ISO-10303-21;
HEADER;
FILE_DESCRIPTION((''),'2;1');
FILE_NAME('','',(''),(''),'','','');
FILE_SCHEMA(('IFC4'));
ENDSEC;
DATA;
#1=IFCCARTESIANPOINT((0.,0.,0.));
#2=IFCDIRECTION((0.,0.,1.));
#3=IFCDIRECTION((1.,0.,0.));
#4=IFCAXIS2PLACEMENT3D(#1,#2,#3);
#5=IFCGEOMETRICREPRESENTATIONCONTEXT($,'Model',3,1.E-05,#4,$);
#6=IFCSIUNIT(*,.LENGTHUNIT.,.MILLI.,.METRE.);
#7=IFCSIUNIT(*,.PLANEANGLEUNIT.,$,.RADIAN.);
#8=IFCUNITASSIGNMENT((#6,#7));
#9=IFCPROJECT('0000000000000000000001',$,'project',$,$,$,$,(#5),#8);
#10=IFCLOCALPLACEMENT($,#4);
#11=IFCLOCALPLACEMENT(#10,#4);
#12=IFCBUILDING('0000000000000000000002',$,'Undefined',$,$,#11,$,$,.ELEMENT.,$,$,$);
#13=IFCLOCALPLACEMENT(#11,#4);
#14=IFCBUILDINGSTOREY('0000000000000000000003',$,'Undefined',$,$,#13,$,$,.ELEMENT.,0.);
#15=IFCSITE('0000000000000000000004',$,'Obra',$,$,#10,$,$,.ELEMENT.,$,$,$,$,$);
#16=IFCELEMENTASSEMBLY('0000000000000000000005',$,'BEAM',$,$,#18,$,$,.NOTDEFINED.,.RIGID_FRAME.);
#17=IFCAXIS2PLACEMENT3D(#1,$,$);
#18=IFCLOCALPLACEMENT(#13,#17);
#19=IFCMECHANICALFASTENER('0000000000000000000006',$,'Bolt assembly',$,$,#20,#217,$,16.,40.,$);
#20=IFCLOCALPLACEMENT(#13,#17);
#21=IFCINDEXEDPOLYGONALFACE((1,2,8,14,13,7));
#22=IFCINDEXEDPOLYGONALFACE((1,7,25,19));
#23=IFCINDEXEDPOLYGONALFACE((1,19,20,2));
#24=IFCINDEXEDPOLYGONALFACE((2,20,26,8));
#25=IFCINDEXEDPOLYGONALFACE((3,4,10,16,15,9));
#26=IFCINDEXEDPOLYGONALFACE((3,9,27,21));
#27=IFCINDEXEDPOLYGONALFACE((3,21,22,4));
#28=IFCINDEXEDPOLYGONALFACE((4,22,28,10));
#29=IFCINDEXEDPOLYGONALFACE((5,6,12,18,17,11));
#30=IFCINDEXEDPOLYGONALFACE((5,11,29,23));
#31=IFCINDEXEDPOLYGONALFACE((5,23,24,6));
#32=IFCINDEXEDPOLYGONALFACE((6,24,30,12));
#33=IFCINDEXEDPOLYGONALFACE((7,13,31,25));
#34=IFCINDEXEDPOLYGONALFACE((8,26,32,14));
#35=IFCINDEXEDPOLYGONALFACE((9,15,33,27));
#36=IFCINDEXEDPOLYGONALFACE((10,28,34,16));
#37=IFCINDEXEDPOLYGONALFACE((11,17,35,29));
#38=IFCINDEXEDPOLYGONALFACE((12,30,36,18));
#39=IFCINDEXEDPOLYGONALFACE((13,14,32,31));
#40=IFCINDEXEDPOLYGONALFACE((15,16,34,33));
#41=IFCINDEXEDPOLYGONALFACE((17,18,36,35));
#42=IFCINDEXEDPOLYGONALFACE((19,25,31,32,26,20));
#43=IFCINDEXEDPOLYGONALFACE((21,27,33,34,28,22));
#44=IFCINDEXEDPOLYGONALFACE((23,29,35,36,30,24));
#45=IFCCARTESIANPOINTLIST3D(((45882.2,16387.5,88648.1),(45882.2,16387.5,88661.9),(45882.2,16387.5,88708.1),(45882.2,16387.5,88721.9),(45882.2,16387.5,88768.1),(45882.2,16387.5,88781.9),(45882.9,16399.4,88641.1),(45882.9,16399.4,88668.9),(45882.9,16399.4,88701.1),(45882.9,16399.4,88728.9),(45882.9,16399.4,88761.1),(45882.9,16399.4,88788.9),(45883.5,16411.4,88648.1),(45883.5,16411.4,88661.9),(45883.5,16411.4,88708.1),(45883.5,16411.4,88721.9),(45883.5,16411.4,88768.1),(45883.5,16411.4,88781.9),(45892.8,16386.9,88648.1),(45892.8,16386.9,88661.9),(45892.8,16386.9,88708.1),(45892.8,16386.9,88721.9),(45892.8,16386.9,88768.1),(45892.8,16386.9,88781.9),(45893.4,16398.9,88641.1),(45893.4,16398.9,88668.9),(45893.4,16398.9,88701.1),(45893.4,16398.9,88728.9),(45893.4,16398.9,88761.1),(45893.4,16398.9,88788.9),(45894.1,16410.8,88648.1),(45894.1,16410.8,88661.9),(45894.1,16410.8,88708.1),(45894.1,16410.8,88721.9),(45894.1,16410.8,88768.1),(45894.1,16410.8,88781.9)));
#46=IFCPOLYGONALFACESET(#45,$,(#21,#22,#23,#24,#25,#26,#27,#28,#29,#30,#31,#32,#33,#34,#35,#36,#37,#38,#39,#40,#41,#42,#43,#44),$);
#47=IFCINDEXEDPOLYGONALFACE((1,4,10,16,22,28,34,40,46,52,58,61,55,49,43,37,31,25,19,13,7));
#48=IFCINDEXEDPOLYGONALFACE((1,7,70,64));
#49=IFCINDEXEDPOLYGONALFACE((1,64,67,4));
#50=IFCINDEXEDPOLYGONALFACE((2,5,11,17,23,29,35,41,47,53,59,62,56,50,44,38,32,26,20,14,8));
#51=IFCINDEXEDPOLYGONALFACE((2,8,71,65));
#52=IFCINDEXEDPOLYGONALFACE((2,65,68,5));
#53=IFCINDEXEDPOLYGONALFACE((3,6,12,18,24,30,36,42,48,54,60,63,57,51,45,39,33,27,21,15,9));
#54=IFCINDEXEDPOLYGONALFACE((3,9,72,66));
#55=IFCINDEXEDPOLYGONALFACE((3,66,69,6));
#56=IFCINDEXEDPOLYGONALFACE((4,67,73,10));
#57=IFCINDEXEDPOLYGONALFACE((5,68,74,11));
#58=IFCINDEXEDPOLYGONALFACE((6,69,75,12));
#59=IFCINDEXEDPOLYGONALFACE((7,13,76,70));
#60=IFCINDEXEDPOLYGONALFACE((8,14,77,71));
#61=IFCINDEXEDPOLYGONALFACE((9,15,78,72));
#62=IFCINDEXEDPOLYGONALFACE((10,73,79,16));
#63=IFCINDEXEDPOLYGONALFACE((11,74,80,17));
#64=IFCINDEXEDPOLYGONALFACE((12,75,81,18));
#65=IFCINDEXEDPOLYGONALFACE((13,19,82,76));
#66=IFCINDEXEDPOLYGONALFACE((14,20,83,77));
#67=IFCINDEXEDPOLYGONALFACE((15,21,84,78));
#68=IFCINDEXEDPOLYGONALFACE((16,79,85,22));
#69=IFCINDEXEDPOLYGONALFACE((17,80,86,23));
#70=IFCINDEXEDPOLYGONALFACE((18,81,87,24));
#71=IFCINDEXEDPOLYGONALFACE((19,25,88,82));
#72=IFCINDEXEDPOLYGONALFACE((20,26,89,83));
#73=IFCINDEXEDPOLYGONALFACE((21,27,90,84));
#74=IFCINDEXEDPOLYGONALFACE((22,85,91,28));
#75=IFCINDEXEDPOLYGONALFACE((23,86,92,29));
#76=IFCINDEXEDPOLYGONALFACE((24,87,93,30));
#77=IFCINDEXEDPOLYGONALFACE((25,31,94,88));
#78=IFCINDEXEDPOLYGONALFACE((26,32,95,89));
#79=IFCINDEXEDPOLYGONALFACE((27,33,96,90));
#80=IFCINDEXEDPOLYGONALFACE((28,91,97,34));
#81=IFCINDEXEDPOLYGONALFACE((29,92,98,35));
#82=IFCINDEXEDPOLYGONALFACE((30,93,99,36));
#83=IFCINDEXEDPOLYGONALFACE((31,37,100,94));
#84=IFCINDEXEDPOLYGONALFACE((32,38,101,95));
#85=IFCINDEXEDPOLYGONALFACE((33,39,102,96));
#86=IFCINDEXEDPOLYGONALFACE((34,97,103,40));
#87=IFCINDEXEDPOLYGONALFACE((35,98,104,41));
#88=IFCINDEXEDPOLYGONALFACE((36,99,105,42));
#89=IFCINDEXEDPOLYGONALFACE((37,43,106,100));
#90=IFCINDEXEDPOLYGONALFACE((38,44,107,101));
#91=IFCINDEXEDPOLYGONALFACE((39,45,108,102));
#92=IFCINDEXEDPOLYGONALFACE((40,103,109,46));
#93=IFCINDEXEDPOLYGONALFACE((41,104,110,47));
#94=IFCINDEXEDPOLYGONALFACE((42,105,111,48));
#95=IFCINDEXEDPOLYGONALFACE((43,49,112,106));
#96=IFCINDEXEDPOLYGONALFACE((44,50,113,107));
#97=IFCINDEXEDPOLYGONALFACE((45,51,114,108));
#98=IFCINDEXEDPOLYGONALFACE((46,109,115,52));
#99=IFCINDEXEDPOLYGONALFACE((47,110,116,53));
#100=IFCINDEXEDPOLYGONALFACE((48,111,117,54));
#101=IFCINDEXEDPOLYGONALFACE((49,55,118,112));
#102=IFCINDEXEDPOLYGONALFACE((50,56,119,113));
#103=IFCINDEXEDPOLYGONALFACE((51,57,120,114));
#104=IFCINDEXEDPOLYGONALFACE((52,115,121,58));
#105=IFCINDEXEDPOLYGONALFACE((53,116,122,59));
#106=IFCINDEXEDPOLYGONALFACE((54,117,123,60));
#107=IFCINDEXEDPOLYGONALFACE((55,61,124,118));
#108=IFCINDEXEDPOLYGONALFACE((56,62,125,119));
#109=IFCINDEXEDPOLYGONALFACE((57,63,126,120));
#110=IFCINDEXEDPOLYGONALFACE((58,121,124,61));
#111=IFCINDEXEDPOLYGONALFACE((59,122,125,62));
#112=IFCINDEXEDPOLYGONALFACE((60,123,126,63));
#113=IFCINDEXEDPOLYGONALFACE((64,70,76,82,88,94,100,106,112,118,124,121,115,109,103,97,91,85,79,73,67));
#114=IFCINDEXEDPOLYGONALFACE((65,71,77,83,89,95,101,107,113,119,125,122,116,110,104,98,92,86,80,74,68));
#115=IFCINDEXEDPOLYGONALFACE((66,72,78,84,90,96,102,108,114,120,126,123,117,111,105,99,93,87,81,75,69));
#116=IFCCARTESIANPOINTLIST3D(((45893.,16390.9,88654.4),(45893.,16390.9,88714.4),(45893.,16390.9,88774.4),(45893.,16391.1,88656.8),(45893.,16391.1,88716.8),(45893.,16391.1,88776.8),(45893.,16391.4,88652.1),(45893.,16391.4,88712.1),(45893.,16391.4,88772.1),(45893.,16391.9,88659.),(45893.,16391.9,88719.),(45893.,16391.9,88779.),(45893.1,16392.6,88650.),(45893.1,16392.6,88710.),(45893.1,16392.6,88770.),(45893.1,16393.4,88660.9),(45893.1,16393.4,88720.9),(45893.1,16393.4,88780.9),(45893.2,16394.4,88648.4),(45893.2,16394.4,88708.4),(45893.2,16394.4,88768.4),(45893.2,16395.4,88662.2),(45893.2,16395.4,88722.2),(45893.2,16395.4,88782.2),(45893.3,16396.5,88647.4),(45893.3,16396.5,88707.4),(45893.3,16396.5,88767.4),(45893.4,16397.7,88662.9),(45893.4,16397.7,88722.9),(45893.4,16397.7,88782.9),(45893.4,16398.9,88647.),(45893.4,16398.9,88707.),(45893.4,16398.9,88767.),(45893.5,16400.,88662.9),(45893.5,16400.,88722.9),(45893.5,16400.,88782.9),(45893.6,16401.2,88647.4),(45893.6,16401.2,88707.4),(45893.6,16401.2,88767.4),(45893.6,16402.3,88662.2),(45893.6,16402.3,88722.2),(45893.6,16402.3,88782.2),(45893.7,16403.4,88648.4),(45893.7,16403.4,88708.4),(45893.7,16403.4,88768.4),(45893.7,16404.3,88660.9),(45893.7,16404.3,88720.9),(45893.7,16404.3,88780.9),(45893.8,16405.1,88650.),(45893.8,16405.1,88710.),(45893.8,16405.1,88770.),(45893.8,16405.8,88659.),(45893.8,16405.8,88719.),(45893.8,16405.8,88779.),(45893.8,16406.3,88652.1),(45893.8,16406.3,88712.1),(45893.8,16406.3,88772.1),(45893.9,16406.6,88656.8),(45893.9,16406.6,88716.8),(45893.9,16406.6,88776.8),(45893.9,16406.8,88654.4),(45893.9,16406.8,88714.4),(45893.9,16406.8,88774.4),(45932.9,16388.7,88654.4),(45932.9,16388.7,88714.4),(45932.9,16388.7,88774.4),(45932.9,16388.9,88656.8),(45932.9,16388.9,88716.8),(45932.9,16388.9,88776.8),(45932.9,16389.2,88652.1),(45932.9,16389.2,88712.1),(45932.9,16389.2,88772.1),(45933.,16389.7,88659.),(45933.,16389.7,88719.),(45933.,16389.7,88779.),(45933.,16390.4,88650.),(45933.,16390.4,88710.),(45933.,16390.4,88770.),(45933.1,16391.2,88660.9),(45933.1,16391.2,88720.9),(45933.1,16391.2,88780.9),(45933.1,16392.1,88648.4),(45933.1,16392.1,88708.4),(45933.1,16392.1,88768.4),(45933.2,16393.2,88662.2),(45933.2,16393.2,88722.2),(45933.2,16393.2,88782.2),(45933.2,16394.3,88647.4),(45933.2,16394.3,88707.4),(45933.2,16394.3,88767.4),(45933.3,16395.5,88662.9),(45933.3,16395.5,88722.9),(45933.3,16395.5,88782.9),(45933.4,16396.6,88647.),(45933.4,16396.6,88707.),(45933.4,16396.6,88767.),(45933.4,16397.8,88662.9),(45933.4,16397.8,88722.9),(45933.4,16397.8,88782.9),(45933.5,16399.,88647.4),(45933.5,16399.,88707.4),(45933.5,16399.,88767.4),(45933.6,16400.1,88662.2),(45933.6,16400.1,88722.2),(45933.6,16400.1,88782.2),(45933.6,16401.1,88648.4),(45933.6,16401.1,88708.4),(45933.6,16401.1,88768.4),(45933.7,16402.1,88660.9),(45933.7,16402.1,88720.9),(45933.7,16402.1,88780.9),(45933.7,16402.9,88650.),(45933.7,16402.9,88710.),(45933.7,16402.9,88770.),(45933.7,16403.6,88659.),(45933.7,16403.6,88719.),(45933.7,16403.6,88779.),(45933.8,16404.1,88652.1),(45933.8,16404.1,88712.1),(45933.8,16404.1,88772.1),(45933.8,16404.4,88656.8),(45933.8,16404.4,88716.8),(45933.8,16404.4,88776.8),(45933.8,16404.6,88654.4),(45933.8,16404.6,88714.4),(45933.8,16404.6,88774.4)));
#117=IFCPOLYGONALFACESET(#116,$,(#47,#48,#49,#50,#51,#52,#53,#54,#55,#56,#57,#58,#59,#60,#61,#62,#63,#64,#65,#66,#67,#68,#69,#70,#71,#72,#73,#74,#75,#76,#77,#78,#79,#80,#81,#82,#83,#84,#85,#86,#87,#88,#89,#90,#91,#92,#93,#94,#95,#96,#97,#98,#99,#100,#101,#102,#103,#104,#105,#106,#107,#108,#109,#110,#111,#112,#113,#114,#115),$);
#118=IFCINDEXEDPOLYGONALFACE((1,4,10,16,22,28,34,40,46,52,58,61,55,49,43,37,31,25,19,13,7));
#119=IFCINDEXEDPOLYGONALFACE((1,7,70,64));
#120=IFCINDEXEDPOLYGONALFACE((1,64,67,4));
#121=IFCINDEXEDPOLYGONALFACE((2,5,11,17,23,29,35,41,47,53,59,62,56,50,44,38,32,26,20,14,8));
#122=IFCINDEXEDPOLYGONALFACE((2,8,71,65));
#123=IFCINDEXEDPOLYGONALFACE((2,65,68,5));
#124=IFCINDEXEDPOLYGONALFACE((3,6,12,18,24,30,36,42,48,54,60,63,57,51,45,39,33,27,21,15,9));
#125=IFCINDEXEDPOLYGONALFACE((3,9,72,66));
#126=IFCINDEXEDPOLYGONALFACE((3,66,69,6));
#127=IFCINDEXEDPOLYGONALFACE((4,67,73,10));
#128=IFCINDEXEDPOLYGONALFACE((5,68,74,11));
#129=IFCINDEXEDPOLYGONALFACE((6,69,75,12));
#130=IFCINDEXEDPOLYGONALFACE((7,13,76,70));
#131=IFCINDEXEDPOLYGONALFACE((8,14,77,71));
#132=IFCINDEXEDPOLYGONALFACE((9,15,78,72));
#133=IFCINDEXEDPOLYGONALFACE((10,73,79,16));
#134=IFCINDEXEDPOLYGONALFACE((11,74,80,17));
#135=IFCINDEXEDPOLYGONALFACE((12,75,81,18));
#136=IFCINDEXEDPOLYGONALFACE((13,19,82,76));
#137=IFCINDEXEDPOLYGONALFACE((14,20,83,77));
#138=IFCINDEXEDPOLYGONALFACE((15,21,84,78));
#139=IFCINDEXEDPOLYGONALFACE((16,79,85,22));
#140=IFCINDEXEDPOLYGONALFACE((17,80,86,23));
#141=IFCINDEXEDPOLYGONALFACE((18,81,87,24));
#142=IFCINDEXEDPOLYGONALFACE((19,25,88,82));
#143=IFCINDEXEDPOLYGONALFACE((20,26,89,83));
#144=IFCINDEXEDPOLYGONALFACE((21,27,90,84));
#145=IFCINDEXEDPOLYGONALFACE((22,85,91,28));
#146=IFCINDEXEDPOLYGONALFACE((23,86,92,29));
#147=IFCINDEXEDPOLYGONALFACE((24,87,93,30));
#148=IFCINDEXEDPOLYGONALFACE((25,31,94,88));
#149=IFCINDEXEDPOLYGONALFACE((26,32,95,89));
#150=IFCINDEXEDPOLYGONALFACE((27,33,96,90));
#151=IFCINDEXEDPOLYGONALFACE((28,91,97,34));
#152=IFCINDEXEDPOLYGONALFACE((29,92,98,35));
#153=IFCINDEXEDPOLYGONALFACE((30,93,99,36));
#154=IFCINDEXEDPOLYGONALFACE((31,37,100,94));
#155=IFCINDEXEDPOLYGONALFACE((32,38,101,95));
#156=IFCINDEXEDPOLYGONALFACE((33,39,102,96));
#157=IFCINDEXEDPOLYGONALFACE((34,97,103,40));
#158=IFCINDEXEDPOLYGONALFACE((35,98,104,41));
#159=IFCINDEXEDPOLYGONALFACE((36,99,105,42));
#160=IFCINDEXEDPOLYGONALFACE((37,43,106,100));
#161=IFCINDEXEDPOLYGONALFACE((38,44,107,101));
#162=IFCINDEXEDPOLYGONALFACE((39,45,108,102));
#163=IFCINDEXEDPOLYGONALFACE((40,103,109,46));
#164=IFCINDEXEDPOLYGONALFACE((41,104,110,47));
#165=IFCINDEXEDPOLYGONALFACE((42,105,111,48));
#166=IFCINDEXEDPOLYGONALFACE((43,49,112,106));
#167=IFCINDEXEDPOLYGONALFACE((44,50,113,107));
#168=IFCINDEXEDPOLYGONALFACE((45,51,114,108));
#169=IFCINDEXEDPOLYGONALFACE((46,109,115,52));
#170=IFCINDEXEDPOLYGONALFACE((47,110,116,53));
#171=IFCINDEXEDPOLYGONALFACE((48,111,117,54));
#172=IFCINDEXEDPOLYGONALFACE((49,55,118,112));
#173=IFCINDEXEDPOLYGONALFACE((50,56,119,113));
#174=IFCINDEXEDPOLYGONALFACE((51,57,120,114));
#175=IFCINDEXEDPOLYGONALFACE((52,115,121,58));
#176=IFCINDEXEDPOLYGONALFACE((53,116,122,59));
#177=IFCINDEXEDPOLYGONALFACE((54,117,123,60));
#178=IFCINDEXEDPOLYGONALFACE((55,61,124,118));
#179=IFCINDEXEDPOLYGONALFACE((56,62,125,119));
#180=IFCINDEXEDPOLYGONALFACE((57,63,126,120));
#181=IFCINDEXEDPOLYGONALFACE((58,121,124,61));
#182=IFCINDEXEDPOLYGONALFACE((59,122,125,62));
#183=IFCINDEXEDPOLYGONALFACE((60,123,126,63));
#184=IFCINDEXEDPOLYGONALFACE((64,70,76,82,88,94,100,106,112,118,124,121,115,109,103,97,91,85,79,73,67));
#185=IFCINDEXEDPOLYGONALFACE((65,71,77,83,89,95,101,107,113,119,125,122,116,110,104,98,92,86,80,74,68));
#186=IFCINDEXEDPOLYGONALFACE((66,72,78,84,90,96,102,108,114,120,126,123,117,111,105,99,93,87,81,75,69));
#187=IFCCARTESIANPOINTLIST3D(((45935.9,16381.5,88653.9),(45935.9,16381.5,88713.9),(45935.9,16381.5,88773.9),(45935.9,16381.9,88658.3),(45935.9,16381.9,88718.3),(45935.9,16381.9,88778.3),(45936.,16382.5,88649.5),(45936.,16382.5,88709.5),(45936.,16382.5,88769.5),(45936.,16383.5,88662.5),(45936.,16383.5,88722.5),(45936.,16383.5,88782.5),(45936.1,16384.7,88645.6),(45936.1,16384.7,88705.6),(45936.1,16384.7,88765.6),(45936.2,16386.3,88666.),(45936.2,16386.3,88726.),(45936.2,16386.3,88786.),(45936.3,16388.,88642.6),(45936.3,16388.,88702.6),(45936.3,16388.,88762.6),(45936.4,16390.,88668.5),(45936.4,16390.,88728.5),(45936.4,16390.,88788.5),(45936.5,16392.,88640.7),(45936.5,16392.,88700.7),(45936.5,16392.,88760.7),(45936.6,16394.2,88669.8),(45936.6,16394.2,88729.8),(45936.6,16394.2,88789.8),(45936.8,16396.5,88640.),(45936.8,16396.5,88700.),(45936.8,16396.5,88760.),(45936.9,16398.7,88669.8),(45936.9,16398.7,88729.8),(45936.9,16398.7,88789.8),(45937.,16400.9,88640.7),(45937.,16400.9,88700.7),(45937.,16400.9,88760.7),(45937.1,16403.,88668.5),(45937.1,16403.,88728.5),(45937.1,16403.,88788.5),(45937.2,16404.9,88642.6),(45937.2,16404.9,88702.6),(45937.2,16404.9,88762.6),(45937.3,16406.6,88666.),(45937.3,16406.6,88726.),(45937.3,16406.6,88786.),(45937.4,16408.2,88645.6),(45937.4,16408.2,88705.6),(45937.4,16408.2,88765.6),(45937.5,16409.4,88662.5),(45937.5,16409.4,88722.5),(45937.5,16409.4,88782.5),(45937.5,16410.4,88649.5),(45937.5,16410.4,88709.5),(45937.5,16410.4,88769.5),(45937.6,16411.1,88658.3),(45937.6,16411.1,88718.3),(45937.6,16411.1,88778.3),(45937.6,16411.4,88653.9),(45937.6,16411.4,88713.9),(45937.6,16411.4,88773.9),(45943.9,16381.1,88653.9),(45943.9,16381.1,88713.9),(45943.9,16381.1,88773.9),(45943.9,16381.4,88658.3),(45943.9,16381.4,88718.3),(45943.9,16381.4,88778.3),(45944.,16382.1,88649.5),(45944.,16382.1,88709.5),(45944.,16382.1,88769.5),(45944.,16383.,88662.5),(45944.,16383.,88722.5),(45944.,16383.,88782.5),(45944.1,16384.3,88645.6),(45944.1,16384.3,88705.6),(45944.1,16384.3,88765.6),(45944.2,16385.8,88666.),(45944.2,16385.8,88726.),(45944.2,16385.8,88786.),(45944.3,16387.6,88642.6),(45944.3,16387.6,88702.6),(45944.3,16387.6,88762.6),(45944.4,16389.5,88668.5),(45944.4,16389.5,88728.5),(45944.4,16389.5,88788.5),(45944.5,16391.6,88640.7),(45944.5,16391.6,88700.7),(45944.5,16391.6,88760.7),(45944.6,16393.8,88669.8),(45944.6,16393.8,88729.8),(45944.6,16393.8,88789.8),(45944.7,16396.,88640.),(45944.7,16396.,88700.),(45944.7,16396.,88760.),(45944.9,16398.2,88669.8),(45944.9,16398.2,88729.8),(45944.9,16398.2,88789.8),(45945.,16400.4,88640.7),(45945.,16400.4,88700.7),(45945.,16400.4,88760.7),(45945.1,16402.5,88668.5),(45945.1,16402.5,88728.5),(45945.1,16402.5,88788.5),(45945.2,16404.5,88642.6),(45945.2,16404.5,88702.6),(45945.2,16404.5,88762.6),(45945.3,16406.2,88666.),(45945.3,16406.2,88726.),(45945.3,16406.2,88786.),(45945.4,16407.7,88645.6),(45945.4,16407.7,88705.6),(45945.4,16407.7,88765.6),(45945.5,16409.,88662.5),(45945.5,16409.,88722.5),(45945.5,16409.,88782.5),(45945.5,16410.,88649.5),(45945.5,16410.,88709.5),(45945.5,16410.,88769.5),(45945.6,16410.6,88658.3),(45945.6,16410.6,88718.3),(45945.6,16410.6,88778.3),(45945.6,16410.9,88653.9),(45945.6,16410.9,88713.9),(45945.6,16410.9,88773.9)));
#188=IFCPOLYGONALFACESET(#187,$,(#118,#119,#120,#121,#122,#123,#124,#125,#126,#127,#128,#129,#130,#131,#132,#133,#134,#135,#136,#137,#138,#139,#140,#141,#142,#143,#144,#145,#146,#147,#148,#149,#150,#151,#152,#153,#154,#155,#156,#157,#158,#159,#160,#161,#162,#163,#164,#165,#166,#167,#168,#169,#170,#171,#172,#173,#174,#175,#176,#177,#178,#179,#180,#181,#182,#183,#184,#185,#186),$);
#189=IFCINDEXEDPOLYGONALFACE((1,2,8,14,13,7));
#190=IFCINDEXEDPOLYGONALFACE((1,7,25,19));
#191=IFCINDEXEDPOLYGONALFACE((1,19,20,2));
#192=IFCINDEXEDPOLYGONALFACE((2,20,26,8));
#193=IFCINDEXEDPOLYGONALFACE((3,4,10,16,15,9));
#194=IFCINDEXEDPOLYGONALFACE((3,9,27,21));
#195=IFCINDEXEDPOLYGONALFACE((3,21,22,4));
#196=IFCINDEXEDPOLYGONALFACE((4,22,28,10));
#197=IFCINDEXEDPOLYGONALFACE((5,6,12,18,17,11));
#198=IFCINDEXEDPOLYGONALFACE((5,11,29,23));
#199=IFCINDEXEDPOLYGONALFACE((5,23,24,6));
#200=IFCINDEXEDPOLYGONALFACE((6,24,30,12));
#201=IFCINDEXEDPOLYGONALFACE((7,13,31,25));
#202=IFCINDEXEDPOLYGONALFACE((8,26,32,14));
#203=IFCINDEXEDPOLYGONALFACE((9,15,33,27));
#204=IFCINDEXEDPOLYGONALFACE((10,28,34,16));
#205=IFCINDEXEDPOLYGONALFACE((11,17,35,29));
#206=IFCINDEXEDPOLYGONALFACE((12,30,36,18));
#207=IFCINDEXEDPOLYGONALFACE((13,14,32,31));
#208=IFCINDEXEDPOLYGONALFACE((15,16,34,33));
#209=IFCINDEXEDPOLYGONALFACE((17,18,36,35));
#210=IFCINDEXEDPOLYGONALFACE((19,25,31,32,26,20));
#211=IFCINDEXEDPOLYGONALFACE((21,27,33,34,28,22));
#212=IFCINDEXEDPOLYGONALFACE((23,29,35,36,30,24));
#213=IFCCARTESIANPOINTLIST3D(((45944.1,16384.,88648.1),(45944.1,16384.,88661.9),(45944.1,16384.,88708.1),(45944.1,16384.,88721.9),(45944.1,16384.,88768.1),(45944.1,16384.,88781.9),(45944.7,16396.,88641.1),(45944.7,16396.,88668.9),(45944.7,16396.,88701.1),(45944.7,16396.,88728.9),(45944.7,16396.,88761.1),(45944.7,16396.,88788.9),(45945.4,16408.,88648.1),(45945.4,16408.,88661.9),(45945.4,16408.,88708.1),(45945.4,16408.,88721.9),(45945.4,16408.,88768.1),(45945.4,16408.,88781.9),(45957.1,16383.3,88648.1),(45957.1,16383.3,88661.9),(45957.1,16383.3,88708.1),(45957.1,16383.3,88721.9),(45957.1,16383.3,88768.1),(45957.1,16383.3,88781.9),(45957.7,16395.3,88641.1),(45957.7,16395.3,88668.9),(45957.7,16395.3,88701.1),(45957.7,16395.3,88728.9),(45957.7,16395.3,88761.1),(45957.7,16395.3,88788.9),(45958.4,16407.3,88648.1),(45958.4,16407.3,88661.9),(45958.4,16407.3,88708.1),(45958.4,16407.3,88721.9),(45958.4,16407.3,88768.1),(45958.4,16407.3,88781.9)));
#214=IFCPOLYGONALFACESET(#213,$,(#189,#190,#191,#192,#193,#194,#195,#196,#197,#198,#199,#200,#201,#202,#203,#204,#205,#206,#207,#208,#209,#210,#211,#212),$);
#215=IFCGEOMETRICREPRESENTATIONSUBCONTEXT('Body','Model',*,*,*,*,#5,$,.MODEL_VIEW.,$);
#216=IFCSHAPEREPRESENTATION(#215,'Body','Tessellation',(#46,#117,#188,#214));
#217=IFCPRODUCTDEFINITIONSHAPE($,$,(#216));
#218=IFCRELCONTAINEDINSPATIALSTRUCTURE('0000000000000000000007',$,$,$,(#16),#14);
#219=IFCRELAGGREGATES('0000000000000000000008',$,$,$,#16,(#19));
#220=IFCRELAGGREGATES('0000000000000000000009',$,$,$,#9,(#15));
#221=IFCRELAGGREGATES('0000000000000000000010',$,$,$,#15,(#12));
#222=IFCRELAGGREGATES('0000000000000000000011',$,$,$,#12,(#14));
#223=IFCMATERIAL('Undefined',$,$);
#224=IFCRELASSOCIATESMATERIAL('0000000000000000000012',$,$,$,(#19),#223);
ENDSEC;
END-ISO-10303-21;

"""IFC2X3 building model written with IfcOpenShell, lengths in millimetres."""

from ifc_helpers import new_model, si_unit, frame, origin_with_axes, origin_2d_with_axis, place, context, subcontext, project, spatial, polyline, circle, outline, extrude, source, transform, mapped, material, element, aggregate, save


model = new_model("IFC2X3")

# Units and contexts
model_context = context("Model", 3, precision=1e-05, world=origin_with_axes())
body_context = subcontext(model_context, "Body", "Model", "MODEL_VIEW")
ifc_project = project(units=[si_unit("LENGTHUNIT", "METRE", prefix="MILLI"), si_unit("PLANEANGLEUNIT", "RADIAN")], contexts=[model_context])

# Site, building, storey
site_placement = place(None, origin_with_axes())
site = spatial("IfcSite", under=ifc_project, at=site_placement, Name="Obra", CompositionType="ELEMENT")
building_placement = place(site_placement, origin_with_axes())
building = spatial("IfcBuilding", under=site, at=building_placement, Name="Undefined", CompositionType="ELEMENT")
storey_placement = place(building_placement, origin_with_axes())
storey = spatial("IfcBuildingStorey", under=building, at=storey_placement, Name="Undefined", CompositionType="ELEMENT", Elevation=0.0)

# Element assembly, mechanical fastener
ifc_material_1 = material(Name="Undefined")
shared_shape_1 = source(origin_with_axes(), body_context, "Body", "SweptSolid", [
    extrude(outline(polyline([(13.9, 0.0), (6.9, 12.0), (-6.9, 12.0), (-13.9, 0.0), (-6.9, -12.0), (6.9, -12.0), (13.9, 0.0)])), frame((0.0, -19.7, 0.0), z_axis=(0.0, 1.0, 0.0), x_axis=(1.0, 0.0, 0.0)), (0.0, 0.0, 1.0), 10.6),
    extrude(circle(Radius=8.0, at=origin_2d_with_axis()), frame((0.0, -9.1, 0.0), z_axis=(0.0, 1.0, 0.0), x_axis=(1.0, 0.0, 0.0)), (0.0, 0.0, 1.0), 40.0),
    extrude(circle(Radius=15.0, at=origin_2d_with_axis()), frame((0.0, 34.3, 0.0), z_axis=(0.0, 1.0, 0.0), x_axis=(1.0, 0.0, 0.0)), (0.0, 0.0, 1.0), 8.0),
    extrude(outline(polyline([(13.9, 0.0), (6.9, 12.0), (-6.9, 12.0), (-13.9, 0.0), (-6.9, -12.0), (6.9, -12.0), (13.9, 0.0)])), frame((0.0, 42.3, 0.0), z_axis=(0.0, 1.0, 0.0), x_axis=(1.0, 0.0, 0.0)), (0.0, 0.0, 1.0), 13.0),
])
assembly_1_placement = place(storey_placement, origin_with_axes())
assembly_1 = element("IfcElementAssembly", 1, at=assembly_1_placement, inside=storey, Name="BEAM", AssemblyPlace="NOTDEFINED", PredefinedType="RIGID_FRAME")
mechanical_fastener_1_placement = place(assembly_1_placement, frame((45905.3, 16448.3, 88835.0), z_axis=(-0.055268, -0.998472, 0.0), x_axis=(0.0, 0.0, -1.0)))
mechanical_fastener_1 = element("IfcMechanicalFastener", 2, at=mechanical_fastener_1_placement, material=ifc_material_1, Name="Bolt assembly", NominalDiameter=16.0, NominalLength=40.0, context=body_context, shape_type="MappedRepresentation", body=[
    mapped(shared_shape_1, transform((60.0, 0.0, 50.0))),
    mapped(shared_shape_1, transform((120.0, 0.0, 50.0))),
    mapped(shared_shape_1, transform((180.0, 0.0, 50.0))),
])
aggregate(assembly_1, [mechanical_fastener_1])

save(model, "model.ifc")
